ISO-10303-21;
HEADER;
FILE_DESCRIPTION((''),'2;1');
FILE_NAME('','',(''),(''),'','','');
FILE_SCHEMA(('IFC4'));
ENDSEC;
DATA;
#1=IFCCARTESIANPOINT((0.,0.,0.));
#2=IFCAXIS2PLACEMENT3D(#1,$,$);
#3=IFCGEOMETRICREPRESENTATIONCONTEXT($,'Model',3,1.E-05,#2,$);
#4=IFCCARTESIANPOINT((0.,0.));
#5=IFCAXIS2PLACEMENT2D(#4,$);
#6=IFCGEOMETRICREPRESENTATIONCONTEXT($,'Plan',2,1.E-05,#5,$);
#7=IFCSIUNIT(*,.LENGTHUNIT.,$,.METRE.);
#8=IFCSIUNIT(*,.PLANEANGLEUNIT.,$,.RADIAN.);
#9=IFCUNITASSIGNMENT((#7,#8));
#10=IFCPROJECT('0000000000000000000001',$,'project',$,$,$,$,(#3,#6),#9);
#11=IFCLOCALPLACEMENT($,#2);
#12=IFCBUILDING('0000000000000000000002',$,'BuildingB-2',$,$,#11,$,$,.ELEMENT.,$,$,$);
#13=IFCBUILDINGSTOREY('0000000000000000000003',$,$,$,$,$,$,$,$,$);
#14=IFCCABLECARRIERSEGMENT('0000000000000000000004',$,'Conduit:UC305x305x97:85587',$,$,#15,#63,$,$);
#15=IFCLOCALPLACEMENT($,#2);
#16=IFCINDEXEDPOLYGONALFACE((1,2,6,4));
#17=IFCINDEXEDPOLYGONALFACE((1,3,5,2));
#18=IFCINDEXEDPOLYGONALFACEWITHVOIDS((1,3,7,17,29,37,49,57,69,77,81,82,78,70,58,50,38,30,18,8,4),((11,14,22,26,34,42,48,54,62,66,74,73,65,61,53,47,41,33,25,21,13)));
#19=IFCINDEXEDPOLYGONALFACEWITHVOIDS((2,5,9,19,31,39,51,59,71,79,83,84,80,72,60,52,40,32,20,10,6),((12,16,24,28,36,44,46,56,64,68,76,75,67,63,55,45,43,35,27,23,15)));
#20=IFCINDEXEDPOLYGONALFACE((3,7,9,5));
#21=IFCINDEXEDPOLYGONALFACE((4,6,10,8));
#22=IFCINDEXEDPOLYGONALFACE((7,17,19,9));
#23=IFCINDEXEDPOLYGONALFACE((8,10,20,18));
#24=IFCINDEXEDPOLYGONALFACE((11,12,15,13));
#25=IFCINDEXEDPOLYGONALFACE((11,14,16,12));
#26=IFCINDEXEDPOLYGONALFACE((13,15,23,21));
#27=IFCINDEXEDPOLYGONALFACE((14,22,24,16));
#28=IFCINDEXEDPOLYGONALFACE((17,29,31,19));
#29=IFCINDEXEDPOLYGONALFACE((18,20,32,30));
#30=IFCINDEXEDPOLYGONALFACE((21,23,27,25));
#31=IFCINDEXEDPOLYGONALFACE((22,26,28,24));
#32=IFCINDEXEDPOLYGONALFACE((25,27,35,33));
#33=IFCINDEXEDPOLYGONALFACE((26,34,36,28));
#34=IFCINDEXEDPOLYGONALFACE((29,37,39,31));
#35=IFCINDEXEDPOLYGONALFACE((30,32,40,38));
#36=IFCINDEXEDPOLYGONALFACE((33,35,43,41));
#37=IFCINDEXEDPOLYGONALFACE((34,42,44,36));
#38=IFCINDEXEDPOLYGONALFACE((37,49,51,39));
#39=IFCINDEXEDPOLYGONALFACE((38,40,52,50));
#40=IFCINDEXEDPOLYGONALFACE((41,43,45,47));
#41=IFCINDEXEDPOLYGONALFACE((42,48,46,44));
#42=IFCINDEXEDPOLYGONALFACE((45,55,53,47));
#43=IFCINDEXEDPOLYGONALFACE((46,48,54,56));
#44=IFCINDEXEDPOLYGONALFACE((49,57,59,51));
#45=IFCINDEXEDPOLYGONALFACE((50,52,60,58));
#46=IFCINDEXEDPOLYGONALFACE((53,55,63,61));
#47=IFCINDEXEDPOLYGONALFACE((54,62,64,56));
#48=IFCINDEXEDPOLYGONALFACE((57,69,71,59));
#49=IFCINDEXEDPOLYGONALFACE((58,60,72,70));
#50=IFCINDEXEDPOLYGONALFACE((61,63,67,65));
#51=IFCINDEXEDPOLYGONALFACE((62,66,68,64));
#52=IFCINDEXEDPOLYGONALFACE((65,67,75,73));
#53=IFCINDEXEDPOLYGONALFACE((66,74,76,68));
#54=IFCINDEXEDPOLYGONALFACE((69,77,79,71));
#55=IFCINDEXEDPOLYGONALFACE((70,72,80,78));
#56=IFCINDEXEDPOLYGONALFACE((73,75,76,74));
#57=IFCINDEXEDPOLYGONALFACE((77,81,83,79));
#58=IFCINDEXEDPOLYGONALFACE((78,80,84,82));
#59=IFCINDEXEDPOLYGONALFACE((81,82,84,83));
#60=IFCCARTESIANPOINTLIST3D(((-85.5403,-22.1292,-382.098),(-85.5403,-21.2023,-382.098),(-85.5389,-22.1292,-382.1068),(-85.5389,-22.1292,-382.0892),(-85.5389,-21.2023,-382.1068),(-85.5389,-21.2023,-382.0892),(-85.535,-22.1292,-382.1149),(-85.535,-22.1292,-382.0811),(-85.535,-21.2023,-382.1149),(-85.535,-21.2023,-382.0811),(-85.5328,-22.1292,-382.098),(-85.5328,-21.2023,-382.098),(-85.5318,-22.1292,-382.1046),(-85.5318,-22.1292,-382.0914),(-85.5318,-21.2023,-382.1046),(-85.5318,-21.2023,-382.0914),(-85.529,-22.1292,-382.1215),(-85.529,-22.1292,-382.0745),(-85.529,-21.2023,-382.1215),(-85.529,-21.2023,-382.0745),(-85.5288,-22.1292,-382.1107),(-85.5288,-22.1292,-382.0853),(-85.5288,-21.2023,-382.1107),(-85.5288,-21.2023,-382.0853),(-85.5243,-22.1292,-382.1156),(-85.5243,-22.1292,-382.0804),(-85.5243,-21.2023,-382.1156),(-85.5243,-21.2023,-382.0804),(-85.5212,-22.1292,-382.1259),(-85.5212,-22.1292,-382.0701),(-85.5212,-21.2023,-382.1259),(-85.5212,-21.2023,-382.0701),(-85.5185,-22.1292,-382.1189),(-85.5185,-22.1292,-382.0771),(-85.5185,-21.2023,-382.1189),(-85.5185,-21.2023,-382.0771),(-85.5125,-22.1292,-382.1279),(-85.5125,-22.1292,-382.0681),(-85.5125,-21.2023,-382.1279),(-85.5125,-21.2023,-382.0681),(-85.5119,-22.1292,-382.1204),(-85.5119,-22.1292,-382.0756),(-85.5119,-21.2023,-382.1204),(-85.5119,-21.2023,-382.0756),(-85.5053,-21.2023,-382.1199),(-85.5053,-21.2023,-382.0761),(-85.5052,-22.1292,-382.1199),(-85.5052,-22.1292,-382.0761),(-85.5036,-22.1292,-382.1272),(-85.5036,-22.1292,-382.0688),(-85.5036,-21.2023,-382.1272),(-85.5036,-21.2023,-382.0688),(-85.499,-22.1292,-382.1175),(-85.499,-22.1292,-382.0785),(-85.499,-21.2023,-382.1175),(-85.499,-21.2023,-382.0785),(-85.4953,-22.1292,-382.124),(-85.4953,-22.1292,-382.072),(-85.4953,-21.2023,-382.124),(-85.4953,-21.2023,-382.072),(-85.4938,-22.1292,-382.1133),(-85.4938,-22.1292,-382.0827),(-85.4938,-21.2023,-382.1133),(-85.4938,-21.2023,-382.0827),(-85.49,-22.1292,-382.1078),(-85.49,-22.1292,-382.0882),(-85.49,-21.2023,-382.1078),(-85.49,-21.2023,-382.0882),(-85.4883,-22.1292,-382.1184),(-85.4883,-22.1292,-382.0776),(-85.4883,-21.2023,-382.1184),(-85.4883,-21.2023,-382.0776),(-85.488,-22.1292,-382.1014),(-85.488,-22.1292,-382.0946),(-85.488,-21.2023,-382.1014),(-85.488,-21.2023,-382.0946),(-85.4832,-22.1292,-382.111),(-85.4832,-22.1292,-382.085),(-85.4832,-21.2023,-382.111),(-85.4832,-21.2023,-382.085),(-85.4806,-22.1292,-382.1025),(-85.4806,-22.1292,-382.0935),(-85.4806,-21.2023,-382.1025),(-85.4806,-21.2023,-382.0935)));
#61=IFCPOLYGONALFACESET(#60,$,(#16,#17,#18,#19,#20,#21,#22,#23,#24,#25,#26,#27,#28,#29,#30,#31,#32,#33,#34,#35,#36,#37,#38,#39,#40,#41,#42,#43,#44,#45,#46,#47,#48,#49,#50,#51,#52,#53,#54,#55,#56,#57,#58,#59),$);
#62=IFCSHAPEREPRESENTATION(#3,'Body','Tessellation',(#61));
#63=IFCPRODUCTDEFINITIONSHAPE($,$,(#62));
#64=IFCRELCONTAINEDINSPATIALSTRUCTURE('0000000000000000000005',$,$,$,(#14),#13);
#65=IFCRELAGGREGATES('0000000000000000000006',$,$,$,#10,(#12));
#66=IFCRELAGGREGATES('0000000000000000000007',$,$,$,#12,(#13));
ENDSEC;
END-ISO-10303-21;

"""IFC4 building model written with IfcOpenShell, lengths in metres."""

from ifc_helpers import new_model, entity, si_unit, origin, origin_2d, place, context, project, spatial, element, save


model = new_model("IFC4")

# Units and contexts
model_context = context("Model", 3, precision=1e-05, world=origin())
plan_context = context("Plan", 2, precision=1e-05, world=origin_2d())
ifc_project = project(units=[si_unit("LENGTHUNIT", "METRE"), si_unit("PLANEANGLEUNIT", "RADIAN")], contexts=[model_context, plan_context])

# Building, storey
building_placement = place(None, origin())
building = spatial("IfcBuilding", under=ifc_project, at=building_placement, Name="BuildingB-2", CompositionType="ELEMENT")
storey = spatial("IfcBuildingStorey", under=building)

# Cable carrier segment
element("IfcCableCarrierSegment", 1, inside=storey, Name="Conduit:UC305x305x97:85587", context=model_context, shape_type="AdvancedSweptSolid", body=[
    entity("IfcSweptDiskSolid", entity("IfcCompositeCurve", [entity("IfcCompositeCurveSegment", "CONTINUOUS", False, entity("IfcPolyline", [entity("IfcCartesianPoint", [85.5103, 22.1292, 382.098]), entity("IfcCartesianPoint", [85.5103, 21.2023, 382.098])]))], False), 0.03, 0.0225),
])

save(model, "model.ifc")
